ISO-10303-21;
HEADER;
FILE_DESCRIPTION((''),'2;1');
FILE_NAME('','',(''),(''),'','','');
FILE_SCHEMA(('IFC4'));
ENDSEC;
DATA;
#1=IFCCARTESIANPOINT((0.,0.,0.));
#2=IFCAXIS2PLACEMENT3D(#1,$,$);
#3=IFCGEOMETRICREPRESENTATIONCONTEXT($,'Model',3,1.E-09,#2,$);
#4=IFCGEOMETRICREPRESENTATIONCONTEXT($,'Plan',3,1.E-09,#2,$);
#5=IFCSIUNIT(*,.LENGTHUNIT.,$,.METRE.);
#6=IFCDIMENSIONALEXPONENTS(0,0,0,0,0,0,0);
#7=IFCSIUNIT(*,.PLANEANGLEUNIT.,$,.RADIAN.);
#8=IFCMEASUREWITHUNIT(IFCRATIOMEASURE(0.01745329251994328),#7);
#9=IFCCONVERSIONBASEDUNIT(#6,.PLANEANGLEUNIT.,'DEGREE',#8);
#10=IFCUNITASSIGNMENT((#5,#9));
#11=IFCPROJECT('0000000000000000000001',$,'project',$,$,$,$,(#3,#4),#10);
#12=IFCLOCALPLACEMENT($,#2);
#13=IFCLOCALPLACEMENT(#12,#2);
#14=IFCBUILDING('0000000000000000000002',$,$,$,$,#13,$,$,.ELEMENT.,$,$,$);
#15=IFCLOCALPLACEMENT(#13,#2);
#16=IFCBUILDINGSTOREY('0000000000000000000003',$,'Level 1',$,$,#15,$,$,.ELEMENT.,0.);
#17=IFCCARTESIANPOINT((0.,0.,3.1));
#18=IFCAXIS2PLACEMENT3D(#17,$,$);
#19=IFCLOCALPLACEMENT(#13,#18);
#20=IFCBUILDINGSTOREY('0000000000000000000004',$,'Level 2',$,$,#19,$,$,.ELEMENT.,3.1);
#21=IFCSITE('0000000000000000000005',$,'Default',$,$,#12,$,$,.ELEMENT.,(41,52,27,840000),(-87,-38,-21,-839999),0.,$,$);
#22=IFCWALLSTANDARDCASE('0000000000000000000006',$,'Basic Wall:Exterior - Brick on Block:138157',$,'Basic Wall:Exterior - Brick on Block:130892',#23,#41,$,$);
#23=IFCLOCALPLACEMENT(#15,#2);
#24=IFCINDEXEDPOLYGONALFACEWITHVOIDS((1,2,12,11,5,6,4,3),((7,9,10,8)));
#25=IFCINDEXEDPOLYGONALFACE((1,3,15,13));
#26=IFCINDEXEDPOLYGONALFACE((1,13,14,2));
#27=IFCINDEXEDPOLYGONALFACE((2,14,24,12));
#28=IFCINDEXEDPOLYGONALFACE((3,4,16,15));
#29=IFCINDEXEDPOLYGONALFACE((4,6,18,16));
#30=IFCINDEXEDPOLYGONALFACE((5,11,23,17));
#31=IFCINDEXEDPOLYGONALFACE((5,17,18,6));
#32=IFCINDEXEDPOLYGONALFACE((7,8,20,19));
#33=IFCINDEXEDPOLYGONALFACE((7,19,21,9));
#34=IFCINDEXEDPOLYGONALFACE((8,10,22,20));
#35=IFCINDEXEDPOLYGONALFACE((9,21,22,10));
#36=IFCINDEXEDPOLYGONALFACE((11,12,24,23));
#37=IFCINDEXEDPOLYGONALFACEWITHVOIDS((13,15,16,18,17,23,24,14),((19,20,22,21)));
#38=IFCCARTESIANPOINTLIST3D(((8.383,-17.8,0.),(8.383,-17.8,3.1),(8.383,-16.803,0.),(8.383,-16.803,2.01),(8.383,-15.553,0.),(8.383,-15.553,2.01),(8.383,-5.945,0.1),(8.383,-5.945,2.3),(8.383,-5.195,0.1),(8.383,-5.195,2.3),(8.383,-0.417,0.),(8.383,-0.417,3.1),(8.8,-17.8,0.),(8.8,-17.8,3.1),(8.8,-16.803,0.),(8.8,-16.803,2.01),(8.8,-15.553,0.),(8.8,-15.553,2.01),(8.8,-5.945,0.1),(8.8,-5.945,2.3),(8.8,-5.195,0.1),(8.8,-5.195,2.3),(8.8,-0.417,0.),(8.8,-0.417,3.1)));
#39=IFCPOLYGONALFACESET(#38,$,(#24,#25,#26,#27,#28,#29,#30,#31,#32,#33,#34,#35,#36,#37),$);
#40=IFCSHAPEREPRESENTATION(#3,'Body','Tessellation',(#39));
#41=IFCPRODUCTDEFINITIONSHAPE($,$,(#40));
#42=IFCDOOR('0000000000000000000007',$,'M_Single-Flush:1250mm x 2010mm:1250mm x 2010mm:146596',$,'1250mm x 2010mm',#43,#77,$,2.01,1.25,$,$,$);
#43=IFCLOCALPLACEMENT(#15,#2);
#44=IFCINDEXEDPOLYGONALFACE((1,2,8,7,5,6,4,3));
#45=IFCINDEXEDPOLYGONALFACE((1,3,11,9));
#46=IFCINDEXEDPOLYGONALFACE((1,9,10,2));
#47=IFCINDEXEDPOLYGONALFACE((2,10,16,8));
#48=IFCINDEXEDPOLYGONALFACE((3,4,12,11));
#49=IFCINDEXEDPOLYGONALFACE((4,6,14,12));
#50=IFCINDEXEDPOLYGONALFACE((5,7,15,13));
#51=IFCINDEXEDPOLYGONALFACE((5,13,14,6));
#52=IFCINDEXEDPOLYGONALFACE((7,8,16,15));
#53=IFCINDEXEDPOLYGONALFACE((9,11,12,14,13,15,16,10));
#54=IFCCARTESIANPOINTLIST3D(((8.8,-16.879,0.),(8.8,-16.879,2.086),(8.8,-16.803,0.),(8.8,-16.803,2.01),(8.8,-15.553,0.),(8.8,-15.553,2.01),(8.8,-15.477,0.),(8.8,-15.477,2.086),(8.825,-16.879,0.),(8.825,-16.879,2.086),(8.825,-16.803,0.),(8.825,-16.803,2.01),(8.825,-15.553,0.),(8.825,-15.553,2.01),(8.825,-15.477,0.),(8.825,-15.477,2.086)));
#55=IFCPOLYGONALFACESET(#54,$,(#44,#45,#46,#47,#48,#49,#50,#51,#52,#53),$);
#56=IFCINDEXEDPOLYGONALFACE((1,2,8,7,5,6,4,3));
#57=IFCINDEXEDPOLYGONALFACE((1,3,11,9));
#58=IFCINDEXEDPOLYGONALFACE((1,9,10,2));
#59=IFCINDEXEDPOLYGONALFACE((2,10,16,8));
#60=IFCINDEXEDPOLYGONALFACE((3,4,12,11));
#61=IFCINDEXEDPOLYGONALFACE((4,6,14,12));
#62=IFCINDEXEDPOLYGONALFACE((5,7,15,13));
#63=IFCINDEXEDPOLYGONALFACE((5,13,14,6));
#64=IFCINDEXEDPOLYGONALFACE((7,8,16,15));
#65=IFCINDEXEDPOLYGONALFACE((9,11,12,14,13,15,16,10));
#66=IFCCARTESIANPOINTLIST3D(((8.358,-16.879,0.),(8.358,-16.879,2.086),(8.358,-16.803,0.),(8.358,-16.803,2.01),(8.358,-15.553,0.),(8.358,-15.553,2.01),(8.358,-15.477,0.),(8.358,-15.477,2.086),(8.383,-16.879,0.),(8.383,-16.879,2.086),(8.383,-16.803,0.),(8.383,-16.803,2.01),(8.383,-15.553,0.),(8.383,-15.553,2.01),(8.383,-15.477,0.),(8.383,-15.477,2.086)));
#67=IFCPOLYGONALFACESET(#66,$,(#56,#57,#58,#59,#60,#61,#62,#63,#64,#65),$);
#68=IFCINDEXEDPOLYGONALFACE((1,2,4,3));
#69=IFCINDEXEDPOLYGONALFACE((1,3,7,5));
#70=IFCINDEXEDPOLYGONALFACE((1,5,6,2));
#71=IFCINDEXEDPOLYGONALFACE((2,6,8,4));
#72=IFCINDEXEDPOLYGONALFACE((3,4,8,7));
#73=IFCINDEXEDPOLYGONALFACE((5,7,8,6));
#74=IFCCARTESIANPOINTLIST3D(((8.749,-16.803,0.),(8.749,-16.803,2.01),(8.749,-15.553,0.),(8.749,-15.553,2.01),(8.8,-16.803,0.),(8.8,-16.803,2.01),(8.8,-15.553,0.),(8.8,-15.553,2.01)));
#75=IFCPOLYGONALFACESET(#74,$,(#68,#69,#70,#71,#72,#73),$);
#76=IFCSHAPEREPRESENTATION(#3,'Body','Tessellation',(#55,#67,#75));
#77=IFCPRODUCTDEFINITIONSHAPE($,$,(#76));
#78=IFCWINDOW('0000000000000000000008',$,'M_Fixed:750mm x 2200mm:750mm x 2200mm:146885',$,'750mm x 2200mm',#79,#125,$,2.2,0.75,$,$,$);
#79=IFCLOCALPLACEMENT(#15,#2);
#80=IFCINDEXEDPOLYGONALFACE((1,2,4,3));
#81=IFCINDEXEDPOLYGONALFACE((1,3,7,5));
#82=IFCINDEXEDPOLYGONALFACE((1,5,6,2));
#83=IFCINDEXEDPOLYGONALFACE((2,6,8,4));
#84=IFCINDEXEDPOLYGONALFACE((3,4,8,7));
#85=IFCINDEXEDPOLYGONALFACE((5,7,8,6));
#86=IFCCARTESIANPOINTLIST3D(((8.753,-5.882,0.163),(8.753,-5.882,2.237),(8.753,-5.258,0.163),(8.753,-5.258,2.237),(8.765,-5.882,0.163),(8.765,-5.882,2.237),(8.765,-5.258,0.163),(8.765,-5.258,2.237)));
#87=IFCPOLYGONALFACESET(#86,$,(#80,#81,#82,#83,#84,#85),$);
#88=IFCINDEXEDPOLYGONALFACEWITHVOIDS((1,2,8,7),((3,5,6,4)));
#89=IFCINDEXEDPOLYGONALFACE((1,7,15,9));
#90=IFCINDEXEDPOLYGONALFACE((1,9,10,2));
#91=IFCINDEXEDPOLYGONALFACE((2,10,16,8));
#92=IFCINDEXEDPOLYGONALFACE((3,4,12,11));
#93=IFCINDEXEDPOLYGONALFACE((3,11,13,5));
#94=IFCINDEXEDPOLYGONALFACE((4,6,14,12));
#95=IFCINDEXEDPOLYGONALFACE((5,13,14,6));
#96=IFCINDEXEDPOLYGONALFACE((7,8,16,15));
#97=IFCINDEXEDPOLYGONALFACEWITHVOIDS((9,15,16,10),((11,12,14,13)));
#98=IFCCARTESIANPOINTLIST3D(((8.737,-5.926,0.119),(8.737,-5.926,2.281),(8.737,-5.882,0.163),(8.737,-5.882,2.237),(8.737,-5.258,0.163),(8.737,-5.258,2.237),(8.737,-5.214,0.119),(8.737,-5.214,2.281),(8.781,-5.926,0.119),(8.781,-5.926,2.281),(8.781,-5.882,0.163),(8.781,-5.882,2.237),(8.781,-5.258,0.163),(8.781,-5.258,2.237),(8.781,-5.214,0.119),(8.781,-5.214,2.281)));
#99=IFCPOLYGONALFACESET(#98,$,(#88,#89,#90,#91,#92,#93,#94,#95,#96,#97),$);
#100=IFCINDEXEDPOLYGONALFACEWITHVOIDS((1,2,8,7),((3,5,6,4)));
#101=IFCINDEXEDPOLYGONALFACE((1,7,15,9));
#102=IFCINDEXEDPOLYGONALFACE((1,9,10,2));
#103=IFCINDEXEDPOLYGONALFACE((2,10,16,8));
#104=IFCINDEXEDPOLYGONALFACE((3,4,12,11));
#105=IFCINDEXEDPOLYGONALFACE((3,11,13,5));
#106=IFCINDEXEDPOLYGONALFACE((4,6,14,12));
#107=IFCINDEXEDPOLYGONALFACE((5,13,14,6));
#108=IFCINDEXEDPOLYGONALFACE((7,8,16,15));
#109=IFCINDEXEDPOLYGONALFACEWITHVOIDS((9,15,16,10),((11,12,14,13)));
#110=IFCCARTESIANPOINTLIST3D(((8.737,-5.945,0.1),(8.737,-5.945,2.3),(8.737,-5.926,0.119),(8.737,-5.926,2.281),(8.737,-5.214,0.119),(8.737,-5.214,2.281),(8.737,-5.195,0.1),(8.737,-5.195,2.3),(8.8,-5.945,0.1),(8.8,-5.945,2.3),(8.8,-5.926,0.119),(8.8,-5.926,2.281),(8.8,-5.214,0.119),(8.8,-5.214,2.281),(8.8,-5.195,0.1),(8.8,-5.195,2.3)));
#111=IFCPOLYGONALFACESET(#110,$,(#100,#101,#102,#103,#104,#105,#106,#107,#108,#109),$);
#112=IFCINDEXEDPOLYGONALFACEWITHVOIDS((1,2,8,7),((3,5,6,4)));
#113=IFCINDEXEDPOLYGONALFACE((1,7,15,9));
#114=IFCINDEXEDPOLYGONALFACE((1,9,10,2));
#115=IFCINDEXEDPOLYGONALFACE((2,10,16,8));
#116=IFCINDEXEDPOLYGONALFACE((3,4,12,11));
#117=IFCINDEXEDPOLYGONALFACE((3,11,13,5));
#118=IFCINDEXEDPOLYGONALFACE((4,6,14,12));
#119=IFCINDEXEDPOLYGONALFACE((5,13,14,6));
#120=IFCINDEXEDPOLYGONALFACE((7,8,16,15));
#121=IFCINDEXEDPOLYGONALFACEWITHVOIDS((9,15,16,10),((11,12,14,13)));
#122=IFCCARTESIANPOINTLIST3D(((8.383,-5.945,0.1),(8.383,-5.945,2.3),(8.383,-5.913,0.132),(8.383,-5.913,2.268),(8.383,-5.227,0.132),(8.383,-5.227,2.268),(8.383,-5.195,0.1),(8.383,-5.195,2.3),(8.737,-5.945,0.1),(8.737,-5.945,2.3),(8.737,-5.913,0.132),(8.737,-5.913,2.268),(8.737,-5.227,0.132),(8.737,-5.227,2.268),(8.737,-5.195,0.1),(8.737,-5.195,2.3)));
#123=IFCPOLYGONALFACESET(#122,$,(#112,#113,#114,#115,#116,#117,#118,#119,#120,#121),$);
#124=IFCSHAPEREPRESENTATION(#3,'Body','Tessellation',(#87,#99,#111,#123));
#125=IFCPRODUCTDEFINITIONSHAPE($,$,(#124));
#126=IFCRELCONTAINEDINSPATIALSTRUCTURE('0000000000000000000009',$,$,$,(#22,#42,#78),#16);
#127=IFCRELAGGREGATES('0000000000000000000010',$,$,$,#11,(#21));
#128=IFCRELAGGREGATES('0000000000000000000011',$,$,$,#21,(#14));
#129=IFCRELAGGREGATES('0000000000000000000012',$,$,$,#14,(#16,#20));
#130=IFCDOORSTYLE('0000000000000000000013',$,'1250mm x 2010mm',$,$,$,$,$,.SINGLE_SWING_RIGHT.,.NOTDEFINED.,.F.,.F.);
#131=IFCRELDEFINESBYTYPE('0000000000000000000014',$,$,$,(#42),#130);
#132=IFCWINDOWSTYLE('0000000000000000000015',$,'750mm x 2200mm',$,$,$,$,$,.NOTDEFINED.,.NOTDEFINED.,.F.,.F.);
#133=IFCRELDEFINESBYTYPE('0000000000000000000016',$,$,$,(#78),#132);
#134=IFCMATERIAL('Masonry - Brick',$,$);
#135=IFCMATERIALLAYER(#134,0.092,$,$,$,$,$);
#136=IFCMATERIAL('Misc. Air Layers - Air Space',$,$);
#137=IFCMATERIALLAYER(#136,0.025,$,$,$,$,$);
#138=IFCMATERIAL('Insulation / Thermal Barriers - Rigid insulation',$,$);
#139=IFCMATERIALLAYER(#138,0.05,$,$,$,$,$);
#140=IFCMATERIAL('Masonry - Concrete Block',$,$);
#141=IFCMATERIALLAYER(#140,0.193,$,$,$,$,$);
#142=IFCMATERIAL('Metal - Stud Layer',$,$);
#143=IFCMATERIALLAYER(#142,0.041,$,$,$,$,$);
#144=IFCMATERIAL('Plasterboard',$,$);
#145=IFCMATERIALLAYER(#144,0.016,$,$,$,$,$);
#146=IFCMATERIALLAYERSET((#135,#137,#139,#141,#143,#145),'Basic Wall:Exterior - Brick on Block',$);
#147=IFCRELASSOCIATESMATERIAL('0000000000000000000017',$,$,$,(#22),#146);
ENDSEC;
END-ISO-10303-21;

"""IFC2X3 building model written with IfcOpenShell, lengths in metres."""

from ifc_helpers import new_model, entity, si_unit, converted_unit, frame, frame_2d, origin, origin_2d_with_axis, place, context, project, spatial, polyline, rectangle, outline, extrude, source, transform, mapped, material, layer, layer_set, layer_usage, type_object, type_shapes, element, fill, save


model = new_model("IFC2X3")

# Units and contexts
model_context = context("Model", 3, precision=1e-09, world=origin())
plan_context = context("Plan", 3, precision=1e-09, world=origin())
ifc_project = project(units=[si_unit("LENGTHUNIT", "METRE"), converted_unit("PLANEANGLEUNIT", "DEGREE", entity("IfcRatioMeasure", 0.01745329251994328), si_unit("PLANEANGLEUNIT", "RADIAN"), dimensions=[0, 0, 0, 0, 0, 0, 0])], contexts=[model_context, plan_context])

# Site, building, storey
site_placement = place(None, origin())
site = spatial("IfcSite", under=ifc_project, at=site_placement, Name="Default", CompositionType="ELEMENT", RefLatitude=(41, 52, 27, 840000), RefLongitude=(-87, -38, -21, -839999), RefElevation=0.0)
building_placement = place(site_placement, origin())
building = spatial("IfcBuilding", under=site, at=building_placement, CompositionType="ELEMENT")
storey_1_placement = place(building_placement, origin())
storey_1 = spatial("IfcBuildingStorey", under=building, at=storey_1_placement, Name="Level 1", CompositionType="ELEMENT", Elevation=0.0)

# Shared definitions
ifc_material_1 = material(Name="Masonry - Brick")
ifc_layer_1 = layer(ifc_material_1, 0.092)
ifc_material_2 = material(Name="Misc. Air Layers - Air Space")
ifc_layer_2 = layer(ifc_material_2, 0.025)
ifc_material_3 = material(Name="Insulation / Thermal Barriers - Rigid insulation")
ifc_layer_3 = layer(ifc_material_3, 0.05)
ifc_material_4 = material(Name="Masonry - Concrete Block")
ifc_layer_4 = layer(ifc_material_4, 0.193)
ifc_material_5 = material(Name="Metal - Stud Layer")
ifc_layer_5 = layer(ifc_material_5, 0.041)
ifc_material_6 = material(Name="Plasterboard")
ifc_layer_6 = layer(ifc_material_6, 0.016)
ifc_layer_set_1 = layer_set([ifc_layer_1, ifc_layer_2, ifc_layer_3, ifc_layer_4, ifc_layer_5, ifc_layer_6], Name="Basic Wall:Exterior - Brick on Block")

# Wall, openings, door, window
ifc_layer_usage_1 = layer_usage(ifc_layer_set_1, "AXIS2", "NEGATIVE", 0.2085)
wall_1_placement = place(storey_1_placement, frame((8.5915, -0.417, 0.0), z_axis=(0.0, 0.0, 1.0), x_axis=(0.0, -1.0, 0.0)))
wall_1 = element("IfcWallStandardCase", 1, at=wall_1_placement, inside=storey_1, material=ifc_layer_usage_1, Name="Basic Wall:Exterior - Brick on Block:138157", ObjectType="Basic Wall:Exterior - Brick on Block:130892", context=model_context, shape_type="SweptSolid", body=[
    extrude(rectangle(XDim=17.383, YDim=0.417, at=frame_2d((8.6915, 0.0), x_axis=(-1.0, 0.0))), origin(), (0.0, 0.0, 1.0), 3.1),
])
opening_1_placement = place(wall_1_placement, frame((15.136, -0.2085, 0.0)))
opening_1 = element("IfcOpeningElement", 2, at=opening_1_placement, cuts=wall_1, ObjectType="Opening", context=model_context, shape_type="SweptSolid", body=[
    extrude(rectangle(XDim=1.25, YDim=2.01, at=frame_2d((1.005, 0.625), x_axis=(0.0, 1.0))), frame((0.0, 0.0, 0.0), z_axis=(0.0, 1.0, 0.0), x_axis=(0.0, 0.0, 1.0)), (0.0, 0.0, 1.0), 0.417),
])
opening_2_placement = place(wall_1_placement, frame((4.778, -0.2085, 0.1)))
opening_2 = element("IfcOpeningElement", 3, at=opening_2_placement, cuts=wall_1, ObjectType="Opening", context=model_context, shape_type="SweptSolid", body=[
    extrude(rectangle(XDim=2.2, YDim=0.75, at=frame_2d((1.1, 0.375), x_axis=(1.0, 0.0))), frame((0.0, 0.0, 0.0), z_axis=(0.0, 1.0, 0.0), x_axis=(0.0, 0.0, 1.0)), (0.0, 0.0, 1.0), 0.417),
])
door_style_1 = type_object("IfcDoorStyle", Name="1250mm x 2010mm", ConstructionType="NOTDEFINED", OperationType="SINGLE_SWING_RIGHT", ParameterTakesPrecedence=False, Sizeable=False)
shared_shape_1 = source(origin(), model_context, "Body", "SweptSolid", [
    extrude(outline(polyline([(-0.701, -1.062), (0.701, -1.062), (0.701, 1.024), (0.625, 1.024), (0.625, -0.986), (-0.625, -0.986), (-0.625, 1.024), (-0.701, 1.024), (-0.701, -1.062)])), frame((0.625, 0.417, 1.024), z_axis=(0.0, 1.0, 0.0), x_axis=(1.0, 0.0, 0.0)), (0.0, 0.0, 1.0), 0.025),
    extrude(outline(polyline([(-1.062, -0.701), (1.024, -0.701), (1.024, -0.625), (-0.986, -0.625), (-0.986, 0.625), (1.024, 0.625), (1.024, 0.701), (-1.062, 0.701), (-1.062, -0.701)])), frame((0.625, -0.025, 1.024), z_axis=(0.0, 1.0, 0.0), x_axis=(0.0, 0.0, -1.0)), (0.0, 0.0, 1.0), 0.025),
    extrude(rectangle(XDim=0.051, YDim=1.25, at=origin_2d_with_axis()), frame((0.625, 0.3915, 0.0), z_axis=(0.0, 0.0, 1.0), x_axis=(0.0, 1.0, 0.0)), (0.0, 0.0, 1.0), 2.01),
])
type_shapes(door_style_1, [shared_shape_1])
door_1_placement = place(opening_1_placement, origin())
door_1 = element("IfcDoor", 4, at=door_1_placement, inside=storey_1, type_object=door_style_1, Name="M_Single-Flush:1250mm x 2010mm:1250mm x 2010mm:146596", ObjectType="1250mm x 2010mm", OverallHeight=2.01, OverallWidth=1.25, context=model_context, shape_type="MappedRepresentation", body=[
    mapped(shared_shape_1, transform((0.0, 0.0, 0.0), scale=1.0)),
])
fill(opening_1, door_1)
window_style_1 = type_object("IfcWindowStyle", Name="750mm x 2200mm", ConstructionType="NOTDEFINED", OperationType="NOTDEFINED", ParameterTakesPrecedence=False, Sizeable=False)
shared_shape_2 = source(origin(), model_context, "Body", "SweptSolid", [
    extrude(rectangle(XDim=0.012, YDim=0.624, at=origin_2d_with_axis()), frame((0.375, 0.376, 0.063), z_axis=(0.0, 0.0, 1.0), x_axis=(0.0, -1.0, 0.0)), (0.0, 0.0, 1.0), 2.074),
    extrude(outline(polyline([(-0.356, -1.081), (0.356, -1.081), (0.356, 1.081), (-0.356, 1.081), (-0.356, -1.081)]), holes=[polyline([(-0.312, -1.037), (-0.312, 1.037), (0.312, 1.037), (0.312, -1.037), (-0.312, -1.037)])]), frame((0.375, 0.354, 1.1), z_axis=(0.0, 1.0, 0.0), x_axis=(1.0, 0.0, 0.0)), (0.0, 0.0, 1.0), 0.044),
    extrude(outline(polyline([(-0.375, -1.1), (0.375, -1.1), (0.375, 1.1), (-0.375, 1.1), (-0.375, -1.1)]), holes=[polyline([(-0.356, -1.081), (-0.356, 1.081), (0.356, 1.081), (0.356, -1.081), (-0.356, -1.081)])]), frame((0.375, 0.354, 1.1), z_axis=(0.0, 1.0, 0.0), x_axis=(1.0, 0.0, 0.0)), (0.0, 0.0, 1.0), 0.063),
    extrude(outline(polyline([(-0.375, -1.1), (0.375, -1.1), (0.375, 1.1), (-0.375, 1.1), (-0.375, -1.1)]), holes=[polyline([(-0.343, -1.068), (-0.343, 1.068), (0.343, 1.068), (0.343, -1.068), (-0.343, -1.068)])]), frame((0.375, 0.0, 1.1), z_axis=(0.0, 1.0, 0.0), x_axis=(1.0, 0.0, 0.0)), (0.0, 0.0, 1.0), 0.354),
])
type_shapes(window_style_1, [shared_shape_2])
window_1_placement = place(opening_2_placement, origin())
window_1 = element("IfcWindow", 5, at=window_1_placement, inside=storey_1, type_object=window_style_1, Name="M_Fixed:750mm x 2200mm:750mm x 2200mm:146885", ObjectType="750mm x 2200mm", OverallHeight=2.2, OverallWidth=0.75, context=model_context, shape_type="MappedRepresentation", body=[
    mapped(shared_shape_2, transform((0.0, 0.0, 0.0), scale=1.0)),
])
fill(opening_2, window_1)

# Shared definitions
storey_2_placement = place(building_placement, frame((0.0, 0.0, 3.1)))
storey_2 = spatial("IfcBuildingStorey", under=building, at=storey_2_placement, Name="Level 2", CompositionType="ELEMENT", Elevation=3.1)

save(model, "model.ifc")
